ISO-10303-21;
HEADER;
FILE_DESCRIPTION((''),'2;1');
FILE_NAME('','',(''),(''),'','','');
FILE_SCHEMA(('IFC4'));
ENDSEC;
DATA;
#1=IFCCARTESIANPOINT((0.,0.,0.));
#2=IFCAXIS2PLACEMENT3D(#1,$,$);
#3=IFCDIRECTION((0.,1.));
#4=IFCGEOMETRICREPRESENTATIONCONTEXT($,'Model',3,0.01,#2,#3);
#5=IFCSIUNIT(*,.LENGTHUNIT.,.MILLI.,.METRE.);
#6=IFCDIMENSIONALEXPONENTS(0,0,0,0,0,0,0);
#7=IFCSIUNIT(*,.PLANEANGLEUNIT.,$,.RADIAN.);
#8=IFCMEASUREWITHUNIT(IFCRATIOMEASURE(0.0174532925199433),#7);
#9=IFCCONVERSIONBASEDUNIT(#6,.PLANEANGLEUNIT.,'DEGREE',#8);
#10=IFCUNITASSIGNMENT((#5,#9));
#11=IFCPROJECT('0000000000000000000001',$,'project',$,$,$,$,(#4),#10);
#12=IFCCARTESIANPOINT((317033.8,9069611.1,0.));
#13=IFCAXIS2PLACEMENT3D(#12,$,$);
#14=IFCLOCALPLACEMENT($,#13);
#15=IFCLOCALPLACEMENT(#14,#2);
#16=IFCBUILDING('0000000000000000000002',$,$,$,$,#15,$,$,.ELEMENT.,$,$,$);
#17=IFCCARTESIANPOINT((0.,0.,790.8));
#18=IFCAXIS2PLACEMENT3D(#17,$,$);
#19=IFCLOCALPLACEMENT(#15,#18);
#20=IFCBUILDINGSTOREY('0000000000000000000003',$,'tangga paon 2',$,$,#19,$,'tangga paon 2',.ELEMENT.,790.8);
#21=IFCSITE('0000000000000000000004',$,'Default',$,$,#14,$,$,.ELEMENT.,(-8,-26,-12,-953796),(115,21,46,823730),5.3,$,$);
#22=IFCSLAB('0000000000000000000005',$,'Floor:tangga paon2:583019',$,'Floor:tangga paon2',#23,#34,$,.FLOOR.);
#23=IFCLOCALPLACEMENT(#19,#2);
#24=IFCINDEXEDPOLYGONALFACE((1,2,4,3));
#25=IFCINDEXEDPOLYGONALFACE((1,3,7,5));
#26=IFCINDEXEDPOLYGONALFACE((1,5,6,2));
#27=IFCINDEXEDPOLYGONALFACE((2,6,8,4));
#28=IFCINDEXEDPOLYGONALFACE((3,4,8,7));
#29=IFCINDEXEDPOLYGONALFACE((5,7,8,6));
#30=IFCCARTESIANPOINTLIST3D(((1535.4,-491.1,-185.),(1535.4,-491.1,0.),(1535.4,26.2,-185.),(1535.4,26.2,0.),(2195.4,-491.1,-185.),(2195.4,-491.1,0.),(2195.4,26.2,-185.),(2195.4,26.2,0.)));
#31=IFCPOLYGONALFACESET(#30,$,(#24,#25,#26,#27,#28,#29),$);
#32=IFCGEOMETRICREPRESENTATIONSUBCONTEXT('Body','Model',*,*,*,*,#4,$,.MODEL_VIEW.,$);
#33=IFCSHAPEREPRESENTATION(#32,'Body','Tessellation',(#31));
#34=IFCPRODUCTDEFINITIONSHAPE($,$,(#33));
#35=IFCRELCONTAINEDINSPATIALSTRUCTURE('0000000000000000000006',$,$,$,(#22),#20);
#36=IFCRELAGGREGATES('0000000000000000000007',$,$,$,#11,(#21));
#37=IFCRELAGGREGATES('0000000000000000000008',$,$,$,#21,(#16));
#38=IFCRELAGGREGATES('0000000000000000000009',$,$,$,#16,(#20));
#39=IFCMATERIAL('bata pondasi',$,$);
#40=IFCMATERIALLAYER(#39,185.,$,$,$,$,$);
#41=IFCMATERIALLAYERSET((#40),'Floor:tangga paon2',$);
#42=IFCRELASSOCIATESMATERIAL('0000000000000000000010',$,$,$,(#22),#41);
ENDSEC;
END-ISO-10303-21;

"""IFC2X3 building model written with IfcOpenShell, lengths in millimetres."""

from ifc_helpers import new_model, entity, si_unit, converted_unit, direction, frame, origin, origin_2d_with_axis, place, context, subcontext, project, spatial, rectangle, extrude, material, layer, layer_set, layer_usage, element, save


model = new_model("IFC2X3")

# Units and contexts
model_context = context("Model", 3, precision=0.01, world=origin(), true_north=direction((0.0, 1.0)))
body_context = subcontext(model_context, "Body", "Model", "MODEL_VIEW")
ifc_project = project(units=[si_unit("LENGTHUNIT", "METRE", prefix="MILLI"), converted_unit("PLANEANGLEUNIT", "DEGREE", entity("IfcRatioMeasure", 0.0174532925199433), si_unit("PLANEANGLEUNIT", "RADIAN"), dimensions=[0, 0, 0, 0, 0, 0, 0])], contexts=[model_context])

# Site, building, storey
site_placement = place(None, frame((317033.8, 9069611.1, 0.0)))
site = spatial("IfcSite", under=ifc_project, at=site_placement, Name="Default", CompositionType="ELEMENT", RefLatitude=(-8, -26, -12, -953796), RefLongitude=(115, 21, 46, 823730), RefElevation=5.3)
building_placement = place(site_placement, origin())
building = spatial("IfcBuilding", under=site, at=building_placement, CompositionType="ELEMENT")
storey_placement = place(building_placement, frame((0.0, 0.0, 790.8)))
storey = spatial("IfcBuildingStorey", under=building, at=storey_placement, Name="tangga paon 2", LongName="tangga paon 2", CompositionType="ELEMENT", Elevation=790.8)

# Slab
ifc_material = material(Name="bata pondasi")
ifc_layer = layer(ifc_material, 185.0)
ifc_layer_set = layer_set([ifc_layer], Name="Floor:tangga paon2")
ifc_layer_usage = layer_usage(ifc_layer_set, "AXIS3", "POSITIVE", 0.0)
slab_placement = place(storey_placement, origin())
element("IfcSlab", 1, at=slab_placement, inside=storey, material=ifc_layer_usage, Name="Floor:tangga paon2:583019", ObjectType="Floor:tangga paon2", PredefinedType="FLOOR", context=body_context, shape_type="SweptSolid", body=[
    extrude(rectangle(XDim=517.3, YDim=660.0, at=origin_2d_with_axis()), frame((1865.4, -232.5, 0.0), z_axis=(0.0, 0.0, -1.0), x_axis=(0.0, 1.0, 0.0)), (0.0, 0.0, 1.0), 185.0),
])

save(model, "model.ifc")
